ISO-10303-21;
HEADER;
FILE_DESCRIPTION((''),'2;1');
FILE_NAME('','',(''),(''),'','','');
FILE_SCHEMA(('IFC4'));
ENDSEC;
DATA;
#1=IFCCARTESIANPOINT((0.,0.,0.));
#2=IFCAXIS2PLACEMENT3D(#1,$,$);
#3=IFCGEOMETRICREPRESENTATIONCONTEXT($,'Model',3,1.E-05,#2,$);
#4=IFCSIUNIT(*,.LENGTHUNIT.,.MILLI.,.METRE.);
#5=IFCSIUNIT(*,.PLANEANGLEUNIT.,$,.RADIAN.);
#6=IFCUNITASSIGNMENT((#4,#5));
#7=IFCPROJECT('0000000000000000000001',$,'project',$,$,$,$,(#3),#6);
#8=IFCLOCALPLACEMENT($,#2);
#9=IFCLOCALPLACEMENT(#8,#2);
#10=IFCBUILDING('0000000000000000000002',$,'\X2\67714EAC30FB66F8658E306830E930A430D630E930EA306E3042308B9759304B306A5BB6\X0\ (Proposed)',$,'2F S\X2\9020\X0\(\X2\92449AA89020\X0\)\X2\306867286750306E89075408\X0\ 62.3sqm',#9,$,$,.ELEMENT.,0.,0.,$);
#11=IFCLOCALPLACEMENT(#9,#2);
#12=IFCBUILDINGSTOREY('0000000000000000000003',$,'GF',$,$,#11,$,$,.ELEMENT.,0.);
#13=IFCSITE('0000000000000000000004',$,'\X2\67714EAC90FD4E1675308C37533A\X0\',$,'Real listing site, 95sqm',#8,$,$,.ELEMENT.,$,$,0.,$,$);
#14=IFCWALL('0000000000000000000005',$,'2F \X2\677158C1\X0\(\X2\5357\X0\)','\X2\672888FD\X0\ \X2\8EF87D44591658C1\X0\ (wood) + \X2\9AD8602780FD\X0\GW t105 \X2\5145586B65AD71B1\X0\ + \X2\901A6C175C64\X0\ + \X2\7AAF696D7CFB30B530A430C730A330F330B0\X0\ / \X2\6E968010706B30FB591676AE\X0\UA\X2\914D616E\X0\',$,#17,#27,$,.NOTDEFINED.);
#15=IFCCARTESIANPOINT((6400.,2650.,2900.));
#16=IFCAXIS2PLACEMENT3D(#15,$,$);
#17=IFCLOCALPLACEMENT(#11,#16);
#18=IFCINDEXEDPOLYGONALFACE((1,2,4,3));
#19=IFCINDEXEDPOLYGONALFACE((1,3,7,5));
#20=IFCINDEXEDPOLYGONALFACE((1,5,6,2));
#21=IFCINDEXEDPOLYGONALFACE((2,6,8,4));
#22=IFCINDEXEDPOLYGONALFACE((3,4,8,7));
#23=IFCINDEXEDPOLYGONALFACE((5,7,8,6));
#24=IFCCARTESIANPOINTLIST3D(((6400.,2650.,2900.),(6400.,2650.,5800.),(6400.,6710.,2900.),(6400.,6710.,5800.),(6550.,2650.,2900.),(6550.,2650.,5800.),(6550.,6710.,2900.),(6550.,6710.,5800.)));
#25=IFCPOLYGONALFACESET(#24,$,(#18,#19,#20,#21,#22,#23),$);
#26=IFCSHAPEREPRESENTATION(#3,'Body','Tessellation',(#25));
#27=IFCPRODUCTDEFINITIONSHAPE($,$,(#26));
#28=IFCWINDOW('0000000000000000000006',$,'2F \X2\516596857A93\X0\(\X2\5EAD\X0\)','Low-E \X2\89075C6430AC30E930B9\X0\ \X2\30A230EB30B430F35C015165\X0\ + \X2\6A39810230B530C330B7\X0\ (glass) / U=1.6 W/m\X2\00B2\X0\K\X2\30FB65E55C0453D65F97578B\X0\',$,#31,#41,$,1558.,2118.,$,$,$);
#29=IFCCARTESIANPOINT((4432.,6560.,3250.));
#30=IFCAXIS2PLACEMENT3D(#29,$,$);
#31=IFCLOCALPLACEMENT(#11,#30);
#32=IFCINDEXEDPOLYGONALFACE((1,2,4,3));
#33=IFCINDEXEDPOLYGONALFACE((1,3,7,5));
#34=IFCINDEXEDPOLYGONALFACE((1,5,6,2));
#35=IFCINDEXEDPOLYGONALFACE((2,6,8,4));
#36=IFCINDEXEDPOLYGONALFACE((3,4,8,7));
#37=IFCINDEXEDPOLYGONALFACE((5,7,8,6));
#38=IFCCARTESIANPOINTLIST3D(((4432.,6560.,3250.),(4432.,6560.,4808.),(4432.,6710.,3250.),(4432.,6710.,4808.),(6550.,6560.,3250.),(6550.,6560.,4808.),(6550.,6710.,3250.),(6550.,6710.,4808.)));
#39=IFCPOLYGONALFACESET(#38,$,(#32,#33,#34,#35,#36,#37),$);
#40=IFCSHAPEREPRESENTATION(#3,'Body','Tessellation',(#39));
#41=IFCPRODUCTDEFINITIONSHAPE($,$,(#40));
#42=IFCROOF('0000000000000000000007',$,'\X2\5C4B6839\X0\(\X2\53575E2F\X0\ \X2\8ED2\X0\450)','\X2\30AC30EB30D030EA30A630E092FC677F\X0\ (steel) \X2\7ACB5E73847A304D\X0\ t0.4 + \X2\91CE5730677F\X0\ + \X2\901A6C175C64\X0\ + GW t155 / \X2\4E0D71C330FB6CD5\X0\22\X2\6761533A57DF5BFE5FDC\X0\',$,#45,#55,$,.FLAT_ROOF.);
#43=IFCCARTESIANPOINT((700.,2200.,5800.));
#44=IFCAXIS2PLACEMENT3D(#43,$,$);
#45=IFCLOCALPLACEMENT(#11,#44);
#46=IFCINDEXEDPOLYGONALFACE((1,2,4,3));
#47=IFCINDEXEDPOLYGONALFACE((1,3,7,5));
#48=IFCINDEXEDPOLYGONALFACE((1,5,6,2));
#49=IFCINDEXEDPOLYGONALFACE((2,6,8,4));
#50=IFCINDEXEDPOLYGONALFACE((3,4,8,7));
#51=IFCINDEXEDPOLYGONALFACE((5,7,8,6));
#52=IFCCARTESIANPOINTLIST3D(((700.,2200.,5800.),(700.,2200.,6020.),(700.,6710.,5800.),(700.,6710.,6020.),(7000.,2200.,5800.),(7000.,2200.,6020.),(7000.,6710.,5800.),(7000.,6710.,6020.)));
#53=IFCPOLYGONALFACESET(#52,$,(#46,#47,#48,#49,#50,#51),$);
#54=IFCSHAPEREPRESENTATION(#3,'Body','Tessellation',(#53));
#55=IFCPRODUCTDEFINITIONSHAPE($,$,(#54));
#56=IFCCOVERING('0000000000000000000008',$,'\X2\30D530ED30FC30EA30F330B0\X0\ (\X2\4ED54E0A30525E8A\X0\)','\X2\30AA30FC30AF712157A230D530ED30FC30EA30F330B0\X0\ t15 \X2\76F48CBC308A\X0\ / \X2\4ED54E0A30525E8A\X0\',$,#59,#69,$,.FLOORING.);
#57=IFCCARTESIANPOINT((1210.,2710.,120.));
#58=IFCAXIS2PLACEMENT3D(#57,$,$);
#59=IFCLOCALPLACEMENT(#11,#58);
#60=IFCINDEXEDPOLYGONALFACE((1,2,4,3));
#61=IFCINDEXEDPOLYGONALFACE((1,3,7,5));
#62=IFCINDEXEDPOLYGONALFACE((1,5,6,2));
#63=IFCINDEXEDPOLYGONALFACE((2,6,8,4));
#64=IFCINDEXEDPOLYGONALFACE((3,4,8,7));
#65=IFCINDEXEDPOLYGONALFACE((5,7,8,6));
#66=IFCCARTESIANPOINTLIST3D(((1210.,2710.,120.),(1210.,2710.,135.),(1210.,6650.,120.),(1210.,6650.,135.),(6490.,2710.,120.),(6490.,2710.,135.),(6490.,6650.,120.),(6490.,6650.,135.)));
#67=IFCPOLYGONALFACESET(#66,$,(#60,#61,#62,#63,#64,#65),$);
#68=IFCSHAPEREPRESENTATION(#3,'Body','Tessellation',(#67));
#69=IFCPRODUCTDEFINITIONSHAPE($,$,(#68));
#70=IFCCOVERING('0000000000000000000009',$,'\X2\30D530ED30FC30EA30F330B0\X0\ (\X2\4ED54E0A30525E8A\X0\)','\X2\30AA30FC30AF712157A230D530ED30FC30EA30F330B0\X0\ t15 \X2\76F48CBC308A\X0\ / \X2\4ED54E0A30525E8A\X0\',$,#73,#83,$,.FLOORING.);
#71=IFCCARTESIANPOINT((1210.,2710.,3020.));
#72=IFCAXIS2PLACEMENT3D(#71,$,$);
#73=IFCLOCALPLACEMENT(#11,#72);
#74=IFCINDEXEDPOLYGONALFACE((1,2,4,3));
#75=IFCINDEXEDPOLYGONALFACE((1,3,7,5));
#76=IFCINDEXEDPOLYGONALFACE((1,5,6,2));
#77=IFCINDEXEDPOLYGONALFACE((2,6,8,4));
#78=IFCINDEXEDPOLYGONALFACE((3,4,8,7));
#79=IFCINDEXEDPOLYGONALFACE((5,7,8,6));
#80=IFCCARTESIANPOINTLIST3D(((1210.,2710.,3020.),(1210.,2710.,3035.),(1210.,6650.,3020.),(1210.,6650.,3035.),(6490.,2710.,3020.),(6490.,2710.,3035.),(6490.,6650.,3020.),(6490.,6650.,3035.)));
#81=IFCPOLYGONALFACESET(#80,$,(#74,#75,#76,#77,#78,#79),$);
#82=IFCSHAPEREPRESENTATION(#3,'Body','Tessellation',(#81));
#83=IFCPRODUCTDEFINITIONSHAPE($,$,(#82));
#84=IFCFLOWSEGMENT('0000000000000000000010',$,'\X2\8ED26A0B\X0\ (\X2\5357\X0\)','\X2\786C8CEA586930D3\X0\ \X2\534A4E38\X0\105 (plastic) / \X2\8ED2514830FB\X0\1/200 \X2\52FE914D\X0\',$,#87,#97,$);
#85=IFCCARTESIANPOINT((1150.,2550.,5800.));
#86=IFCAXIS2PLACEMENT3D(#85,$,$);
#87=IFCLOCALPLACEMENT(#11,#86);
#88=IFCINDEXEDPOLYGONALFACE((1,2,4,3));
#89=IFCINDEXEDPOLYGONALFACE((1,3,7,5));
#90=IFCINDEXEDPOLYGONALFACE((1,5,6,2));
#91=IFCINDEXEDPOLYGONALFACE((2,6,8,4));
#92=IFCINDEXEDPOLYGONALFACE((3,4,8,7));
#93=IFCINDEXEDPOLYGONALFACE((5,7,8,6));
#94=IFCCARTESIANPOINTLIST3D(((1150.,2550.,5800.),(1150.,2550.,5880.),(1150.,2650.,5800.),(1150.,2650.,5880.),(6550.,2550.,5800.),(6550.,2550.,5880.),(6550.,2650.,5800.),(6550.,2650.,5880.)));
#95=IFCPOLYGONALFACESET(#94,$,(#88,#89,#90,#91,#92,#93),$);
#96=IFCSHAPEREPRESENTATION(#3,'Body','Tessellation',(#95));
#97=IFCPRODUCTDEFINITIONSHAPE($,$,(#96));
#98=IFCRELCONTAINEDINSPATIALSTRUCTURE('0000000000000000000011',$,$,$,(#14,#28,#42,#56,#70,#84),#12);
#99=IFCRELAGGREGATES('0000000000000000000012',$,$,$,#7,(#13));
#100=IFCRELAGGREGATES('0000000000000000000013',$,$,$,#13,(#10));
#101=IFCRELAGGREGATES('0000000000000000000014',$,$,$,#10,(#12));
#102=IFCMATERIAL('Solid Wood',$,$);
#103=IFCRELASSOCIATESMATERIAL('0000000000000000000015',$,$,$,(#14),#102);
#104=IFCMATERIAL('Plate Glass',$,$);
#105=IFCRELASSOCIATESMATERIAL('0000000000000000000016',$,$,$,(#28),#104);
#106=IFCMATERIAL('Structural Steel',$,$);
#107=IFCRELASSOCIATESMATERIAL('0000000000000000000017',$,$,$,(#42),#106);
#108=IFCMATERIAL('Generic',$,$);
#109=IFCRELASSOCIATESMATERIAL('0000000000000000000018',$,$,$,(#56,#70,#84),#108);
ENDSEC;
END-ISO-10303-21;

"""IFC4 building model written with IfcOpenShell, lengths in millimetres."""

from ifc_helpers import new_model, si_unit, frame, frame_2d, origin, place, context, project, spatial, rectangle, extrude, material, element, fill, save


model = new_model("IFC4")

# Units and contexts
model_context = context("Model", 3, precision=1e-05, world=origin())
ifc_project = project(units=[si_unit("LENGTHUNIT", "METRE", prefix="MILLI"), si_unit("PLANEANGLEUNIT", "RADIAN")], contexts=[model_context])

# Site, building, storey
site_placement = place(None, origin())
site = spatial("IfcSite", under=ifc_project, at=site_placement, Name="東京都世田谷区", ObjectType="Real listing site, 95sqm", CompositionType="ELEMENT", RefElevation=0.0)
building_placement = place(site_placement, origin())
building = spatial("IfcBuilding", under=site, at=building_placement, Name="東京・書斎とライブラリのある静かな家 (Proposed)", ObjectType="2F S造(鉄骨造)と木材の複合 62.3sqm", CompositionType="ELEMENT", ElevationOfRefHeight=0.0, ElevationOfTerrain=0.0)
storey_placement = place(building_placement, origin())
storey = spatial("IfcBuildingStorey", under=building, at=storey_placement, Name="GF", CompositionType="ELEMENT", Elevation=0.0)

# Shared definitions
ifc_material_1 = material(Name="Solid Wood")

# Wall, opening, window
ifc_material_2 = material(Name="Plate Glass")
wall_1_placement = place(storey_placement, frame((6400.0, 2650.0, 2900.0)))
wall_1 = element("IfcWall", 1, at=wall_1_placement, inside=storey, material=ifc_material_1, Name="2F 東壁(南)", Description="木製 軸組外壁 (wood) + 高性能GW t105 充填断熱 + 通気層 + 窯業系サイディング / 準耐火・外皮UA配慮", PredefinedType="NOTDEFINED", context=model_context, shape_type="SweptSolid", body=[
    extrude(rectangle(XDim=150.0, YDim=4060.0, at=frame_2d((75.0, 2030.0))), frame((6400.0, 2650.0, 2900.0)), (0.0, 0.0, 1.0), 2900.0),
])
opening_1_placement = place(storey_placement, frame((4432.0, 6560.0, 3250.0)))
opening_1 = element("IfcOpeningElement", 2, at=opening_1_placement, cuts=wall_1, PredefinedType="NOTDEFINED", context=model_context, shape_type="SweptSolid", body=[
    extrude(rectangle(XDim=2118.0, YDim=150.0, at=frame_2d((1059.0, 75.0))), frame((4432.0, 6560.0, 3250.0)), (0.0, 0.0, 1.0), 1558.0),
])
window_1_placement = place(storey_placement, frame((4432.0, 6560.0, 3250.0)))
window_1 = element("IfcWindow", 3, at=window_1_placement, inside=storey, material=ifc_material_2, Name="2F 入隅窓(庭)", Description="Low-E 複層ガラス アルゴン封入 + 樹脂サッシ (glass) / U=1.6 W/m²K・日射取得型", OverallHeight=1558.0, OverallWidth=2118.0, context=model_context, shape_type="SweptSolid", body=[
    extrude(rectangle(XDim=2118.0, YDim=150.0, at=frame_2d((1059.0, 75.0))), frame((4432.0, 6560.0, 3250.0)), (0.0, 0.0, 1.0), 1558.0),
])
fill(opening_1, window_1)

# Roof
ifc_material_3 = material(Name="Structural Steel")
for number, where, name in (
    (4, (700.0, 2200.0, 5800.0), "屋根(南帯 軒450)"),
):
    element("IfcRoof", number, at=place(storey_placement, frame(where)), inside=storey, material=ifc_material_3, Name=name, Description="ガルバリウム鋼板 (steel) 立平葺き t0.4 + 野地板 + 通気層 + GW t155 / 不燃・法22条区域対応", PredefinedType="FLAT_ROOF", context=model_context, shape_type="SweptSolid", body=[
        extrude(rectangle(XDim=6300.0, YDim=4510.0, at=frame_2d((3150.0, 2255.0))), frame((700.0, 2200.0, 5800.0)), (0.0, 0.0, 1.0), 220.0),
    ])

# Coverings
ifc_material_4 = material(Name="Generic")
covering_1_placement = place(storey_placement, frame((1210.0, 2710.0, 120.0)))
element("IfcCovering", 5, at=covering_1_placement, inside=storey, material=ifc_material_4, Name="フローリング (仕上げ床)", Description="オーク無垢フローリング t15 直貼り / 仕上げ床", PredefinedType="FLOORING", context=model_context, shape_type="SweptSolid", body=[
    extrude(rectangle(XDim=5280.0, YDim=3940.0, at=frame_2d((2640.0, 1970.0))), frame((1210.0, 2710.0, 120.0)), (0.0, 0.0, 1.0), 15.0),
])
covering_2_placement = place(storey_placement, frame((1210.0, 2710.0, 3020.0)))
element("IfcCovering", 6, at=covering_2_placement, inside=storey, material=ifc_material_4, Name="フローリング (仕上げ床)", Description="オーク無垢フローリング t15 直貼り / 仕上げ床", PredefinedType="FLOORING", context=model_context, shape_type="SweptSolid", body=[
    extrude(rectangle(XDim=5280.0, YDim=3940.0, at=frame_2d((2640.0, 1970.0))), frame((1210.0, 2710.0, 3020.0)), (0.0, 0.0, 1.0), 15.0),
])

# Flow segment
flow_segment_placement = place(storey_placement, frame((1150.0, 2550.0, 5800.0)))
element("IfcFlowSegment", 7, at=flow_segment_placement, inside=storey, material=ifc_material_4, Name="軒樋 (南)", Description="硬質塩ビ 半丸105 (plastic) / 軒先・1/200 勾配", context=model_context, shape_type="SweptSolid", body=[
    extrude(rectangle(XDim=5400.0, YDim=100.0, at=frame_2d((2700.0, 50.0))), frame((1150.0, 2550.0, 5800.0)), (0.0, 0.0, 1.0), 80.0),
])

save(model, "model.ifc")
